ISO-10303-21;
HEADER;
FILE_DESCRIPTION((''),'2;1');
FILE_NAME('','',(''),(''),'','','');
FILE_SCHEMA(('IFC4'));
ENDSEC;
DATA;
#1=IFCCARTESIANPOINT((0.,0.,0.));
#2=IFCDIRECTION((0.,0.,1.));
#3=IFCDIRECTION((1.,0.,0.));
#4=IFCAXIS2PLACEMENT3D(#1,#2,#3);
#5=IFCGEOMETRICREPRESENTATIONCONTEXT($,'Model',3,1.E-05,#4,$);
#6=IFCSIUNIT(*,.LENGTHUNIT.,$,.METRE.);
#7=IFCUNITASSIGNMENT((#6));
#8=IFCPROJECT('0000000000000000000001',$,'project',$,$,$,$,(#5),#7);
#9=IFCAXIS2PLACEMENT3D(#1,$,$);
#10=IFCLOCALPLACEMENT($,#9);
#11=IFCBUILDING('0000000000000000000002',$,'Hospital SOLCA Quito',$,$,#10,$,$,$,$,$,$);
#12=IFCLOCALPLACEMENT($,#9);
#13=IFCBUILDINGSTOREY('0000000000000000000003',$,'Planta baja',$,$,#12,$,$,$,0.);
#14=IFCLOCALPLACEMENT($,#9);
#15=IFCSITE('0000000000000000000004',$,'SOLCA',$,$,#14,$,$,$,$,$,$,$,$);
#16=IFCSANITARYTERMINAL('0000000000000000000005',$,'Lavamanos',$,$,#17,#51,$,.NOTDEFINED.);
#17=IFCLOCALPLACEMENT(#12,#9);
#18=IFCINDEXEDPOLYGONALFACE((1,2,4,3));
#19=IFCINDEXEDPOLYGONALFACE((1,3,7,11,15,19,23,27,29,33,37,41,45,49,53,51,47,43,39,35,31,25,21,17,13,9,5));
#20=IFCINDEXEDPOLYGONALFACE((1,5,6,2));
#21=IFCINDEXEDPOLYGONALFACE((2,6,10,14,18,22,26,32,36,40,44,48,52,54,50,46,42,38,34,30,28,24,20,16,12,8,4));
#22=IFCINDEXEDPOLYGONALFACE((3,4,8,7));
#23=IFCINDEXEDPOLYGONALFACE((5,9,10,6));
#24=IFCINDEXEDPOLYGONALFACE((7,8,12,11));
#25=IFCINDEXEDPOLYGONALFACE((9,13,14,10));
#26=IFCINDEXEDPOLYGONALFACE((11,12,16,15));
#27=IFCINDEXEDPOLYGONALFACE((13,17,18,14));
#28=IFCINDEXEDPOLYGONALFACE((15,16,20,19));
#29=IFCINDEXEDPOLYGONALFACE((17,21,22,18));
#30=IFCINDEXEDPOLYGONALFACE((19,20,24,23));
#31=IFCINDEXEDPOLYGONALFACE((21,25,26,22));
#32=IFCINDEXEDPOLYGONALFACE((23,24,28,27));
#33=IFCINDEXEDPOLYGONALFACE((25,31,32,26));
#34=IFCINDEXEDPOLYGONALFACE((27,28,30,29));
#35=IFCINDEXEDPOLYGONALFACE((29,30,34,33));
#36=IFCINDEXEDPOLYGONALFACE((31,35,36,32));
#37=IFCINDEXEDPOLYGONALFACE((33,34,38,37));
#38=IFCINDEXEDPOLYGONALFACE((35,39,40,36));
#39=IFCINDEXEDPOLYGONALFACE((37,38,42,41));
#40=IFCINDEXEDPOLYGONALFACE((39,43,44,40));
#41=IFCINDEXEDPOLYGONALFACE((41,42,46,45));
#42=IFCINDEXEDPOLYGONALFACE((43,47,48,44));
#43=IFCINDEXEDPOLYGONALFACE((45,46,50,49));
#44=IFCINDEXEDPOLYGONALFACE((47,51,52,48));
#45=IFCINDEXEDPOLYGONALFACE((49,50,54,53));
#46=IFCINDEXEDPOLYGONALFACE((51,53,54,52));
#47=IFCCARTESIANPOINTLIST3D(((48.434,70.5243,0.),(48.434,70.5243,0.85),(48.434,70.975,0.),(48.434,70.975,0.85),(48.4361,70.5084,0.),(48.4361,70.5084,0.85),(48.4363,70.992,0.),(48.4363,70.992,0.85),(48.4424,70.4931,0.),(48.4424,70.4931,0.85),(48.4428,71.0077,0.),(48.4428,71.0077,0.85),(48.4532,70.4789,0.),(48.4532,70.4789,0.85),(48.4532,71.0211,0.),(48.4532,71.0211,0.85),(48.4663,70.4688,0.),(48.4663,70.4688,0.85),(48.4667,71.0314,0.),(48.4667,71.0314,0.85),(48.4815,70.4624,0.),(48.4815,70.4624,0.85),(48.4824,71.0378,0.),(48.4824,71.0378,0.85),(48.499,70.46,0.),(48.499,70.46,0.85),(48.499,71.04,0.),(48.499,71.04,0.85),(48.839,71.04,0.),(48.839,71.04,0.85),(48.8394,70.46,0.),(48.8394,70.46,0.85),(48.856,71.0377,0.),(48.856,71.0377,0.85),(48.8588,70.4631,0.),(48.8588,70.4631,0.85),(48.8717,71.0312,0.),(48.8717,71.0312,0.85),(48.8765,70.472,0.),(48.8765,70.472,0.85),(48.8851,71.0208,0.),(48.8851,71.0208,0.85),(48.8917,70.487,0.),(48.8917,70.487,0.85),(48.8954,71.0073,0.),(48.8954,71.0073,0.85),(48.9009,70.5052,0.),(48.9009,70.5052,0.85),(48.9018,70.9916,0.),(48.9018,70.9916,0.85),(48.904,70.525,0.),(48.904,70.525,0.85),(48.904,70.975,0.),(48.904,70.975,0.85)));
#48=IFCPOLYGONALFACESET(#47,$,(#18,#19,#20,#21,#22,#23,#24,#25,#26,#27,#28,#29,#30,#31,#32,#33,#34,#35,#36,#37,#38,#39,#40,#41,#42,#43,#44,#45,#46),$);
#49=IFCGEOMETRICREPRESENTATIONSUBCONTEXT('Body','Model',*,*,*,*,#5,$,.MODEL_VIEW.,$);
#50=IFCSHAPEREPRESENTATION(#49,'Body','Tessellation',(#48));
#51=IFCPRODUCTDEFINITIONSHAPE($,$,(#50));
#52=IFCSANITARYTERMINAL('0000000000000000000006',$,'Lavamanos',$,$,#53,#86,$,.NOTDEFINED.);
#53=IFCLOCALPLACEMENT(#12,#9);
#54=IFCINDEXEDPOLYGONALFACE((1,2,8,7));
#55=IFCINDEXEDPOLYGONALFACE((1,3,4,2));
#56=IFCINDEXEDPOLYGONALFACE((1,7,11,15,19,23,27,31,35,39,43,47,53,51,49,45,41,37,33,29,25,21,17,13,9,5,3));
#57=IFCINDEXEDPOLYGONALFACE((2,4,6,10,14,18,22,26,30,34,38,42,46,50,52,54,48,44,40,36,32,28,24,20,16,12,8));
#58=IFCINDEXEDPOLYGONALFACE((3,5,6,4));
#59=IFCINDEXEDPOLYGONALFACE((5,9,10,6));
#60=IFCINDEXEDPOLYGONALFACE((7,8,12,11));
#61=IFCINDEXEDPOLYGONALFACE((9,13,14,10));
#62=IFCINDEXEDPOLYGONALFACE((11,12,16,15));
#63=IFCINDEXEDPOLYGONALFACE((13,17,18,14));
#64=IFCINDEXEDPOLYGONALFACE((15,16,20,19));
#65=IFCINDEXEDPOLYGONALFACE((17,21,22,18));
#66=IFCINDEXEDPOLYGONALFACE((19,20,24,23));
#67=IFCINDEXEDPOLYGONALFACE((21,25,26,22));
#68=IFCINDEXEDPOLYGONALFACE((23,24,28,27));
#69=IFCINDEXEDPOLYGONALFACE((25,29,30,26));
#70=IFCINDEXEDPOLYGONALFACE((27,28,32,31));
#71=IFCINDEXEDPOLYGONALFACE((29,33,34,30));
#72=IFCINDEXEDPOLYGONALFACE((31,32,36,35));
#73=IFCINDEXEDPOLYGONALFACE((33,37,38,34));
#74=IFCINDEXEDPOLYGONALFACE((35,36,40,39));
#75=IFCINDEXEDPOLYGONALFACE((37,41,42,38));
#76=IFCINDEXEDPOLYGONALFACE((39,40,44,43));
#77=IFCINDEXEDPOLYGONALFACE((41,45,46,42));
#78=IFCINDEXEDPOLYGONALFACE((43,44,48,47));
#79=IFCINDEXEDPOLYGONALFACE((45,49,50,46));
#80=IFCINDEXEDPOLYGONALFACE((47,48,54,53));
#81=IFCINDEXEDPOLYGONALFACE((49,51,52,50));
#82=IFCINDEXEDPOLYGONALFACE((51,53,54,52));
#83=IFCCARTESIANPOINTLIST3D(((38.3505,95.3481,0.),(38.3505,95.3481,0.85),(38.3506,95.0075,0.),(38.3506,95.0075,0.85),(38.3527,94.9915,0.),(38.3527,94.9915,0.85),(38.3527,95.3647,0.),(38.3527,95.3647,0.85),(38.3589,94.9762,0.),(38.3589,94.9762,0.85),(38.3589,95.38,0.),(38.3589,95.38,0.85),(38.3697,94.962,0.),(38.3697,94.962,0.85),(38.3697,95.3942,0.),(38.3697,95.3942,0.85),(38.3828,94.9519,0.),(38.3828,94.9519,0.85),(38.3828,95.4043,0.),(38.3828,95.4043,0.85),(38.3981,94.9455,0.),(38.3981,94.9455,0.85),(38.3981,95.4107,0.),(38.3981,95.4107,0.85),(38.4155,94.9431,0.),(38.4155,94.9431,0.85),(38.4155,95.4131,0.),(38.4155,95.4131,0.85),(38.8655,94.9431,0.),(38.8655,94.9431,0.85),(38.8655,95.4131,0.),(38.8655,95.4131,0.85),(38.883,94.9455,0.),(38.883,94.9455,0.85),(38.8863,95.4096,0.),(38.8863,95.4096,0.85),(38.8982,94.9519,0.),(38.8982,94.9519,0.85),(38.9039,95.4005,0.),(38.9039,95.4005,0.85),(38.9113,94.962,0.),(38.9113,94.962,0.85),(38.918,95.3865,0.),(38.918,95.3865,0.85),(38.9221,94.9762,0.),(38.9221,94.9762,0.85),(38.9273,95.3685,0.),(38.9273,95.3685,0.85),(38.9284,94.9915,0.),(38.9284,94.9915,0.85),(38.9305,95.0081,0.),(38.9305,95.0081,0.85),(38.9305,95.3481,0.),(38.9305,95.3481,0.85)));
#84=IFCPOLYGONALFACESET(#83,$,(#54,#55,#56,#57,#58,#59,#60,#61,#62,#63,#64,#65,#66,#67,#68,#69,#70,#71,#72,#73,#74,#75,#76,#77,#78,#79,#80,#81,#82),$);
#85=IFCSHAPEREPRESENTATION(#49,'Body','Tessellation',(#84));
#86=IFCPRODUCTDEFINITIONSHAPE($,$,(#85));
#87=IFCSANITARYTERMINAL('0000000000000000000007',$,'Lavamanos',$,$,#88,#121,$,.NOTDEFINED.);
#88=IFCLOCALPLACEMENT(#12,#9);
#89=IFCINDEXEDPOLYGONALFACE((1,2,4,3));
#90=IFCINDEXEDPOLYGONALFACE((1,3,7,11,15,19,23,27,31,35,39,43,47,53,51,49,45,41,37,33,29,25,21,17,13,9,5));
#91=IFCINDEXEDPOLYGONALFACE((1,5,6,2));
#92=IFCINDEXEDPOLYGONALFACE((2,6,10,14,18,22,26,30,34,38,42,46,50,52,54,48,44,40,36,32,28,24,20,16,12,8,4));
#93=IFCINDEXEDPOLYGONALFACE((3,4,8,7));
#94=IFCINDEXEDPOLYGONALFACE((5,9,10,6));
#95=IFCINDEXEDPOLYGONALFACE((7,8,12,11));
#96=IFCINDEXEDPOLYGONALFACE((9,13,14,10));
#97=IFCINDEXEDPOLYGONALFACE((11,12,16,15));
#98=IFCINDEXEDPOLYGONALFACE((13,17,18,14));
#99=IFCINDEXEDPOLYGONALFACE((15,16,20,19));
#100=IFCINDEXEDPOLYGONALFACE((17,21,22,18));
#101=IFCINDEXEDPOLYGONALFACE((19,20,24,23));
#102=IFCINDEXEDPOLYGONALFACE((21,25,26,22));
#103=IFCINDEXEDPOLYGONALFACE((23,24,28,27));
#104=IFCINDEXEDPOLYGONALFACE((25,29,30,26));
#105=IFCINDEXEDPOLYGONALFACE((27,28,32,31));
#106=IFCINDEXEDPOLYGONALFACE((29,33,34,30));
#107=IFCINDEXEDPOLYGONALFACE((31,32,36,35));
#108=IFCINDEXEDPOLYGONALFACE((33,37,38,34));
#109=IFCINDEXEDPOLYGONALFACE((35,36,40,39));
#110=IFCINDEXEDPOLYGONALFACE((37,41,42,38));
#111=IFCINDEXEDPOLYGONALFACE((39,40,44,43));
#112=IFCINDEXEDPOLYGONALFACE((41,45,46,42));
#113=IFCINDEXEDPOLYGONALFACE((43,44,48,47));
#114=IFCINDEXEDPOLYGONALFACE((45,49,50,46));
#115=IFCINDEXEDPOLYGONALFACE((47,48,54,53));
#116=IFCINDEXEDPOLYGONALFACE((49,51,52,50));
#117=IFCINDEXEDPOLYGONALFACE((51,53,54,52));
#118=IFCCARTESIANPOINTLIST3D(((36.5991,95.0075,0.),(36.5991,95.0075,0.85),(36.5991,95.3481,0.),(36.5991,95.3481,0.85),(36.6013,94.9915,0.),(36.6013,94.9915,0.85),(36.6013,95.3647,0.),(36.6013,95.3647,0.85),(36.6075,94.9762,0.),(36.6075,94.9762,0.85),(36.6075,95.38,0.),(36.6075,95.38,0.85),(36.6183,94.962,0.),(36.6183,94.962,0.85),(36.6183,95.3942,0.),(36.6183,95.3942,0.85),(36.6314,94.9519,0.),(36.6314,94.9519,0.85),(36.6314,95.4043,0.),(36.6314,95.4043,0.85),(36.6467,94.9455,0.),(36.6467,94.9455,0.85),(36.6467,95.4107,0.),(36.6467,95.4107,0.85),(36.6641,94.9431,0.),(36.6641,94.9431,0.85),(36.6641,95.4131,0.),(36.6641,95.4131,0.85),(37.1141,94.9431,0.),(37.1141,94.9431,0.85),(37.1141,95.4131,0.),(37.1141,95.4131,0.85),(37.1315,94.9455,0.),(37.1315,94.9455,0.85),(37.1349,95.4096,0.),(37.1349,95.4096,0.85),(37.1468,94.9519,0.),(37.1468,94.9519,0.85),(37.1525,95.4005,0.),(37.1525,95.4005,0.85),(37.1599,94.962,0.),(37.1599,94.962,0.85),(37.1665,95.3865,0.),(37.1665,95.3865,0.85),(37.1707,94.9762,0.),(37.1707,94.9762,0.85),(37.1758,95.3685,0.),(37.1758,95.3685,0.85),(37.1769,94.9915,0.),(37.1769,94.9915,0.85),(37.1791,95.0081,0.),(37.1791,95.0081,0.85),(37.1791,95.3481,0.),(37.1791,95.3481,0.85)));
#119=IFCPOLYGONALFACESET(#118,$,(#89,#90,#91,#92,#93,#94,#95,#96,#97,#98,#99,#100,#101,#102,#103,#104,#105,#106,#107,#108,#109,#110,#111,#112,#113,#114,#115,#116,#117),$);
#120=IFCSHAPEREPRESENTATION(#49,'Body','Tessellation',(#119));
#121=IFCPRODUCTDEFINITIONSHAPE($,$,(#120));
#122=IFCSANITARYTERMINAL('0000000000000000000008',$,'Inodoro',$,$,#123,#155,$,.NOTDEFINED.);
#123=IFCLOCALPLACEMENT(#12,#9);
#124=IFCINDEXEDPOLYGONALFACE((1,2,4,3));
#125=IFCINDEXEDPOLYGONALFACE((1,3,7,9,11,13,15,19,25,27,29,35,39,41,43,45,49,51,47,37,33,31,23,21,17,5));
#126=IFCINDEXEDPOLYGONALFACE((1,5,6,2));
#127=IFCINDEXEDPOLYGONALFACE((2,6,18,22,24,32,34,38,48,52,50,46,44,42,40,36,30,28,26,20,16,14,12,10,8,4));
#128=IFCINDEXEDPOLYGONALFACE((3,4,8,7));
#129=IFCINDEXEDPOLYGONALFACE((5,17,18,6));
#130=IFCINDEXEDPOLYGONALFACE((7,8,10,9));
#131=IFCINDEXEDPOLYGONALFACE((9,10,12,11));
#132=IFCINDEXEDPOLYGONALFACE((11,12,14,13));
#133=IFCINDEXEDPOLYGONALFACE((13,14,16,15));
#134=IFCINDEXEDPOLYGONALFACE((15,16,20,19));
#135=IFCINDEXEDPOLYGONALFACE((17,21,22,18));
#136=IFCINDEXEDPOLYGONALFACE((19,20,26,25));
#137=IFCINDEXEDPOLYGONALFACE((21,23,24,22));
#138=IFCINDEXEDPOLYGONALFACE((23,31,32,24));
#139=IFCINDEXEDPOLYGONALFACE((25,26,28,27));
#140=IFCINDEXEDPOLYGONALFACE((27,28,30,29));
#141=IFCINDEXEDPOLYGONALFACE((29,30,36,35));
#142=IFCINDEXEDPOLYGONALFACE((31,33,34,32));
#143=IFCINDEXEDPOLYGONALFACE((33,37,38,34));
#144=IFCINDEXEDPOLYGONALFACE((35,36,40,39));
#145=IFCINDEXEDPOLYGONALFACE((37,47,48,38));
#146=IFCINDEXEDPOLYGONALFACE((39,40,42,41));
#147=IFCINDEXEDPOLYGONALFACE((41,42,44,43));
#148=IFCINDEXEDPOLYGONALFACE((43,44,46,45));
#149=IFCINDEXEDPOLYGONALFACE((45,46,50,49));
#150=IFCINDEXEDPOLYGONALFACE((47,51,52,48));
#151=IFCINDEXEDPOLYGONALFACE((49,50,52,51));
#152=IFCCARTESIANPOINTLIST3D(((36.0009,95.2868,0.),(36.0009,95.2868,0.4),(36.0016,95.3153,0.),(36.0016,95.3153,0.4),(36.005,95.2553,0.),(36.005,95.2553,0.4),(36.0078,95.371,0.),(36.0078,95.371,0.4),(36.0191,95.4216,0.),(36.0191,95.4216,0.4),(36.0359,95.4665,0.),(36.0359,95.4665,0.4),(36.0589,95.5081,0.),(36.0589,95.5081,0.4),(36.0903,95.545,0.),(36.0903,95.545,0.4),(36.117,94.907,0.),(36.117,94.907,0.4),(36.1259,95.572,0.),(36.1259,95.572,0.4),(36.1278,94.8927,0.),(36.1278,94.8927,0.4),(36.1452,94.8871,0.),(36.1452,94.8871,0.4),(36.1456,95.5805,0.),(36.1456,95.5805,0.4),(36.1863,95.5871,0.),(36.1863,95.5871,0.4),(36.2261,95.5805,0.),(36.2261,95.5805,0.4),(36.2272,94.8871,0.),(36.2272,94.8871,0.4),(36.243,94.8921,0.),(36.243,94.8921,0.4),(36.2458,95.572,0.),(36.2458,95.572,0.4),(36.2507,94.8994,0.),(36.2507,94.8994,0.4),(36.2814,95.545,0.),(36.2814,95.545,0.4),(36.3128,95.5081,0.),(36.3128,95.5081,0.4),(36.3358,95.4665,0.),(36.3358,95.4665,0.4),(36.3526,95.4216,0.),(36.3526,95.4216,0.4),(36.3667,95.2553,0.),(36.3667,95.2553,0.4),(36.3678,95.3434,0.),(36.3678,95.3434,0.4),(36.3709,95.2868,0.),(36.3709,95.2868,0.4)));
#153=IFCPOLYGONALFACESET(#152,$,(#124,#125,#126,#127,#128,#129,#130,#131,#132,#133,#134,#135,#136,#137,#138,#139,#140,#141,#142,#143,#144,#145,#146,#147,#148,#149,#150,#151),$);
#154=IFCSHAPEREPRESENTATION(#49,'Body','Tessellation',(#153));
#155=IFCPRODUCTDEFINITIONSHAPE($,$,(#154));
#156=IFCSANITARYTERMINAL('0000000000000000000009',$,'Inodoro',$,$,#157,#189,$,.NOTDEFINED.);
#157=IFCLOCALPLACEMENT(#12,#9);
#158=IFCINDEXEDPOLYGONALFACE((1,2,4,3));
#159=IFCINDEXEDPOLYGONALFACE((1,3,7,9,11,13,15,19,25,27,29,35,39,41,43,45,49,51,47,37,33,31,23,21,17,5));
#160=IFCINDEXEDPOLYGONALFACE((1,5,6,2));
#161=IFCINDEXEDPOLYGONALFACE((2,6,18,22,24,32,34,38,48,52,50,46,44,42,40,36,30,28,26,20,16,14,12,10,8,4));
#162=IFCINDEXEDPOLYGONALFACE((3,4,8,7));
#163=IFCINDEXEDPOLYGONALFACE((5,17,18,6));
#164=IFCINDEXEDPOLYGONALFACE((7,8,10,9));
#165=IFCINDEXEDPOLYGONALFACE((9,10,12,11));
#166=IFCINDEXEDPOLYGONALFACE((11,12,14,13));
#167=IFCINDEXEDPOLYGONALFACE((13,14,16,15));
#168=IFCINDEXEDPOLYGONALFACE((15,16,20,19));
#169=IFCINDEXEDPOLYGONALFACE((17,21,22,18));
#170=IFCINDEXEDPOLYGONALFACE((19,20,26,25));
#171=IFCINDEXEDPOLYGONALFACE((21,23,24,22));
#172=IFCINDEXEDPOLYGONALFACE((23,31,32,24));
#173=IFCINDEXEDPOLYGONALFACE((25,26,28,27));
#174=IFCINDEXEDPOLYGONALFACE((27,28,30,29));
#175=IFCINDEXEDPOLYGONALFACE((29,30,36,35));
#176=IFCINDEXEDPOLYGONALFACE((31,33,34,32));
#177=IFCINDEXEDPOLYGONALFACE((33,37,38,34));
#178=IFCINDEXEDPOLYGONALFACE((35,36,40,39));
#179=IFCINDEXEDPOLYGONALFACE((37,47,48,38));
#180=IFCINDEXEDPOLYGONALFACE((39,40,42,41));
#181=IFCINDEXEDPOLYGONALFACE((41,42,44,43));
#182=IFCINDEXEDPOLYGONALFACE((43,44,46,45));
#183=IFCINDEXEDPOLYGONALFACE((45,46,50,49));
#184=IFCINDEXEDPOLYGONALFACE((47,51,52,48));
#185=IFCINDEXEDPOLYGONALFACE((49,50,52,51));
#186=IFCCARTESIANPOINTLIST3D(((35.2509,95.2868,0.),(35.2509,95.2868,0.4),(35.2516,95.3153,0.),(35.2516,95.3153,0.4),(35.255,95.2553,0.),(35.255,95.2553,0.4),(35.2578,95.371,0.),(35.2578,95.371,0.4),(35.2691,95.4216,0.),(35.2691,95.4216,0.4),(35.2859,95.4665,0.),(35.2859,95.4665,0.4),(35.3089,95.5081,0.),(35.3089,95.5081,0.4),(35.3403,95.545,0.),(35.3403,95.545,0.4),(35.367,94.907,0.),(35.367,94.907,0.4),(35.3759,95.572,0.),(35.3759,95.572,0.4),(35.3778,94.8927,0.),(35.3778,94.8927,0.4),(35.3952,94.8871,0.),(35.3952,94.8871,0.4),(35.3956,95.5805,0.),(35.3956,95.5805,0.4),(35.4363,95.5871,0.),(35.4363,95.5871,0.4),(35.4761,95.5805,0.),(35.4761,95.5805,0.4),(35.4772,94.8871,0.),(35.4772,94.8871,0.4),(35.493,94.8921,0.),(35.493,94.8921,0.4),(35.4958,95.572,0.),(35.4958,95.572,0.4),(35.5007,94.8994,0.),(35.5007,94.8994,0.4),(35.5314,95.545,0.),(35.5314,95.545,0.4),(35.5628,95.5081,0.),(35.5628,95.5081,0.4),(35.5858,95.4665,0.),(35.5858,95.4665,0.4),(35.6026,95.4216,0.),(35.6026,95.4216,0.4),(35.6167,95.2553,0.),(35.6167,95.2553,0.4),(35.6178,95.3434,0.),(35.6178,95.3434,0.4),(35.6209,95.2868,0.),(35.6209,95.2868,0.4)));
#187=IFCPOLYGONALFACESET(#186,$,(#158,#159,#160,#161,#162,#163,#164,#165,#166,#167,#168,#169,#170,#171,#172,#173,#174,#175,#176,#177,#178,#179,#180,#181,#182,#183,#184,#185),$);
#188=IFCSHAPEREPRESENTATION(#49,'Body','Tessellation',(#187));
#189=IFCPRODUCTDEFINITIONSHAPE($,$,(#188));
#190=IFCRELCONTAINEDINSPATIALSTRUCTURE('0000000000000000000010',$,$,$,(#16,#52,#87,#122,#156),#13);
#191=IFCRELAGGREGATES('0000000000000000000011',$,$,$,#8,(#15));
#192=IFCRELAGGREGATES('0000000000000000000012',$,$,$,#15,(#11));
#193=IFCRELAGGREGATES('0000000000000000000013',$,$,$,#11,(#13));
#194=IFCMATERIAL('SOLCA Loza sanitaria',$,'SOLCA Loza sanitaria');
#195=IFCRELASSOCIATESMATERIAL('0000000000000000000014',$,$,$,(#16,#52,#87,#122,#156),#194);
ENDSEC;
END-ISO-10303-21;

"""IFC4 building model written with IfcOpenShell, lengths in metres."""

from ifc_helpers import new_model, si_unit, origin, origin_with_axes, place, context, subcontext, project, spatial, polyline, outline, extrude, material, element, save


model = new_model("IFC4")

# Units and contexts
model_context = context("Model", 3, precision=1e-05, world=origin_with_axes())
body_context = subcontext(model_context, "Body", "Model", "MODEL_VIEW")
ifc_project = project(units=[si_unit("LENGTHUNIT", "METRE")], contexts=[model_context])

# Site, building, storey
site_placement = place(None, origin())
site = spatial("IfcSite", under=ifc_project, at=site_placement, Name="SOLCA")
building_placement = place(None, origin())
building = spatial("IfcBuilding", under=site, at=building_placement, Name="Hospital SOLCA Quito")
storey_placement = place(None, origin())
storey = spatial("IfcBuildingStorey", under=building, at=storey_placement, Name="Planta baja", Elevation=0.0)

# Sanitary terminals
ifc_material = material(Name="SOLCA Loza sanitaria", Category="SOLCA Loza sanitaria")
sanitary_terminal_1_placement = place(storey_placement, origin_with_axes())
element("IfcSanitaryTerminal", 1, at=sanitary_terminal_1_placement, inside=storey, material=ifc_material, Name="Lavamanos", PredefinedType="NOTDEFINED", context=body_context, shape_type="SweptSolid", body=[
    extrude(outline(polyline([(48.499, 70.46), (48.4815, 70.4624), (48.4663, 70.4688), (48.4532, 70.4789), (48.4424, 70.4931), (48.4361, 70.5084), (48.434, 70.5243), (48.434, 70.975), (48.4363, 70.992), (48.4428, 71.0077), (48.4532, 71.0211), (48.4667, 71.0314), (48.4824, 71.0378), (48.499, 71.04), (48.839, 71.04), (48.856, 71.0377), (48.8717, 71.0312), (48.8851, 71.0208), (48.8954, 71.0073), (48.9018, 70.9916), (48.904, 70.975), (48.904, 70.525), (48.9009, 70.5052), (48.8917, 70.487), (48.8765, 70.472), (48.8588, 70.4631), (48.8394, 70.46), (48.499, 70.46)])), origin_with_axes(), (0.0, 0.0, 1.0), 0.85),
])
sanitary_terminal_2_placement = place(storey_placement, origin_with_axes())
element("IfcSanitaryTerminal", 2, at=sanitary_terminal_2_placement, inside=storey, material=ifc_material, Name="Lavamanos", PredefinedType="NOTDEFINED", context=body_context, shape_type="SweptSolid", body=[
    extrude(outline(polyline([(38.4155, 94.9431), (38.3981, 94.9455), (38.3828, 94.9519), (38.3697, 94.962), (38.3589, 94.9762), (38.3527, 94.9915), (38.3506, 95.0075), (38.3505, 95.3481), (38.3527, 95.3647), (38.3589, 95.38), (38.3697, 95.3942), (38.3828, 95.4043), (38.3981, 95.4107), (38.4155, 95.4131), (38.8655, 95.4131), (38.8863, 95.4096), (38.9039, 95.4005), (38.918, 95.3865), (38.9273, 95.3685), (38.9305, 95.3481), (38.9305, 95.0081), (38.9284, 94.9915), (38.9221, 94.9762), (38.9113, 94.962), (38.8982, 94.9519), (38.883, 94.9455), (38.8655, 94.9431), (38.4155, 94.9431)])), origin_with_axes(), (0.0, 0.0, 1.0), 0.85),
])
sanitary_terminal_3_placement = place(storey_placement, origin_with_axes())
element("IfcSanitaryTerminal", 3, at=sanitary_terminal_3_placement, inside=storey, material=ifc_material, Name="Lavamanos", PredefinedType="NOTDEFINED", context=body_context, shape_type="SweptSolid", body=[
    extrude(outline(polyline([(36.6641, 94.9431), (36.6467, 94.9455), (36.6314, 94.9519), (36.6183, 94.962), (36.6075, 94.9762), (36.6013, 94.9915), (36.5991, 95.0075), (36.5991, 95.3481), (36.6013, 95.3647), (36.6075, 95.38), (36.6183, 95.3942), (36.6314, 95.4043), (36.6467, 95.4107), (36.6641, 95.4131), (37.1141, 95.4131), (37.1349, 95.4096), (37.1525, 95.4005), (37.1665, 95.3865), (37.1758, 95.3685), (37.1791, 95.3481), (37.1791, 95.0081), (37.1769, 94.9915), (37.1707, 94.9762), (37.1599, 94.962), (37.1468, 94.9519), (37.1315, 94.9455), (37.1141, 94.9431), (36.6641, 94.9431)])), origin_with_axes(), (0.0, 0.0, 1.0), 0.85),
])
sanitary_terminal_4_placement = place(storey_placement, origin_with_axes())
element("IfcSanitaryTerminal", 4, at=sanitary_terminal_4_placement, inside=storey, material=ifc_material, Name="Inodoro", PredefinedType="NOTDEFINED", context=body_context, shape_type="SweptSolid", body=[
    extrude(outline(polyline([(36.1452, 94.8871), (36.1278, 94.8927), (36.117, 94.907), (36.005, 95.2553), (36.0009, 95.2868), (36.0016, 95.3153), (36.0078, 95.371), (36.0191, 95.4216), (36.0359, 95.4665), (36.0589, 95.5081), (36.0903, 95.545), (36.1259, 95.572), (36.1456, 95.5805), (36.1863, 95.5871), (36.2261, 95.5805), (36.2458, 95.572), (36.2814, 95.545), (36.3128, 95.5081), (36.3358, 95.4665), (36.3526, 95.4216), (36.3678, 95.3434), (36.3709, 95.2868), (36.3667, 95.2553), (36.2507, 94.8994), (36.243, 94.8921), (36.2272, 94.8871), (36.1452, 94.8871)])), origin_with_axes(), (0.0, 0.0, 1.0), 0.4),
])
sanitary_terminal_5_placement = place(storey_placement, origin_with_axes())
element("IfcSanitaryTerminal", 5, at=sanitary_terminal_5_placement, inside=storey, material=ifc_material, Name="Inodoro", PredefinedType="NOTDEFINED", context=body_context, shape_type="SweptSolid", body=[
    extrude(outline(polyline([(35.3952, 94.8871), (35.3778, 94.8927), (35.367, 94.907), (35.255, 95.2553), (35.2509, 95.2868), (35.2516, 95.3153), (35.2578, 95.371), (35.2691, 95.4216), (35.2859, 95.4665), (35.3089, 95.5081), (35.3403, 95.545), (35.3759, 95.572), (35.3956, 95.5805), (35.4363, 95.5871), (35.4761, 95.5805), (35.4958, 95.572), (35.5314, 95.545), (35.5628, 95.5081), (35.5858, 95.4665), (35.6026, 95.4216), (35.6178, 95.3434), (35.6209, 95.2868), (35.6167, 95.2553), (35.5007, 94.8994), (35.493, 94.8921), (35.4772, 94.8871), (35.3952, 94.8871)])), origin_with_axes(), (0.0, 0.0, 1.0), 0.4),
])

save(model, "model.ifc")
